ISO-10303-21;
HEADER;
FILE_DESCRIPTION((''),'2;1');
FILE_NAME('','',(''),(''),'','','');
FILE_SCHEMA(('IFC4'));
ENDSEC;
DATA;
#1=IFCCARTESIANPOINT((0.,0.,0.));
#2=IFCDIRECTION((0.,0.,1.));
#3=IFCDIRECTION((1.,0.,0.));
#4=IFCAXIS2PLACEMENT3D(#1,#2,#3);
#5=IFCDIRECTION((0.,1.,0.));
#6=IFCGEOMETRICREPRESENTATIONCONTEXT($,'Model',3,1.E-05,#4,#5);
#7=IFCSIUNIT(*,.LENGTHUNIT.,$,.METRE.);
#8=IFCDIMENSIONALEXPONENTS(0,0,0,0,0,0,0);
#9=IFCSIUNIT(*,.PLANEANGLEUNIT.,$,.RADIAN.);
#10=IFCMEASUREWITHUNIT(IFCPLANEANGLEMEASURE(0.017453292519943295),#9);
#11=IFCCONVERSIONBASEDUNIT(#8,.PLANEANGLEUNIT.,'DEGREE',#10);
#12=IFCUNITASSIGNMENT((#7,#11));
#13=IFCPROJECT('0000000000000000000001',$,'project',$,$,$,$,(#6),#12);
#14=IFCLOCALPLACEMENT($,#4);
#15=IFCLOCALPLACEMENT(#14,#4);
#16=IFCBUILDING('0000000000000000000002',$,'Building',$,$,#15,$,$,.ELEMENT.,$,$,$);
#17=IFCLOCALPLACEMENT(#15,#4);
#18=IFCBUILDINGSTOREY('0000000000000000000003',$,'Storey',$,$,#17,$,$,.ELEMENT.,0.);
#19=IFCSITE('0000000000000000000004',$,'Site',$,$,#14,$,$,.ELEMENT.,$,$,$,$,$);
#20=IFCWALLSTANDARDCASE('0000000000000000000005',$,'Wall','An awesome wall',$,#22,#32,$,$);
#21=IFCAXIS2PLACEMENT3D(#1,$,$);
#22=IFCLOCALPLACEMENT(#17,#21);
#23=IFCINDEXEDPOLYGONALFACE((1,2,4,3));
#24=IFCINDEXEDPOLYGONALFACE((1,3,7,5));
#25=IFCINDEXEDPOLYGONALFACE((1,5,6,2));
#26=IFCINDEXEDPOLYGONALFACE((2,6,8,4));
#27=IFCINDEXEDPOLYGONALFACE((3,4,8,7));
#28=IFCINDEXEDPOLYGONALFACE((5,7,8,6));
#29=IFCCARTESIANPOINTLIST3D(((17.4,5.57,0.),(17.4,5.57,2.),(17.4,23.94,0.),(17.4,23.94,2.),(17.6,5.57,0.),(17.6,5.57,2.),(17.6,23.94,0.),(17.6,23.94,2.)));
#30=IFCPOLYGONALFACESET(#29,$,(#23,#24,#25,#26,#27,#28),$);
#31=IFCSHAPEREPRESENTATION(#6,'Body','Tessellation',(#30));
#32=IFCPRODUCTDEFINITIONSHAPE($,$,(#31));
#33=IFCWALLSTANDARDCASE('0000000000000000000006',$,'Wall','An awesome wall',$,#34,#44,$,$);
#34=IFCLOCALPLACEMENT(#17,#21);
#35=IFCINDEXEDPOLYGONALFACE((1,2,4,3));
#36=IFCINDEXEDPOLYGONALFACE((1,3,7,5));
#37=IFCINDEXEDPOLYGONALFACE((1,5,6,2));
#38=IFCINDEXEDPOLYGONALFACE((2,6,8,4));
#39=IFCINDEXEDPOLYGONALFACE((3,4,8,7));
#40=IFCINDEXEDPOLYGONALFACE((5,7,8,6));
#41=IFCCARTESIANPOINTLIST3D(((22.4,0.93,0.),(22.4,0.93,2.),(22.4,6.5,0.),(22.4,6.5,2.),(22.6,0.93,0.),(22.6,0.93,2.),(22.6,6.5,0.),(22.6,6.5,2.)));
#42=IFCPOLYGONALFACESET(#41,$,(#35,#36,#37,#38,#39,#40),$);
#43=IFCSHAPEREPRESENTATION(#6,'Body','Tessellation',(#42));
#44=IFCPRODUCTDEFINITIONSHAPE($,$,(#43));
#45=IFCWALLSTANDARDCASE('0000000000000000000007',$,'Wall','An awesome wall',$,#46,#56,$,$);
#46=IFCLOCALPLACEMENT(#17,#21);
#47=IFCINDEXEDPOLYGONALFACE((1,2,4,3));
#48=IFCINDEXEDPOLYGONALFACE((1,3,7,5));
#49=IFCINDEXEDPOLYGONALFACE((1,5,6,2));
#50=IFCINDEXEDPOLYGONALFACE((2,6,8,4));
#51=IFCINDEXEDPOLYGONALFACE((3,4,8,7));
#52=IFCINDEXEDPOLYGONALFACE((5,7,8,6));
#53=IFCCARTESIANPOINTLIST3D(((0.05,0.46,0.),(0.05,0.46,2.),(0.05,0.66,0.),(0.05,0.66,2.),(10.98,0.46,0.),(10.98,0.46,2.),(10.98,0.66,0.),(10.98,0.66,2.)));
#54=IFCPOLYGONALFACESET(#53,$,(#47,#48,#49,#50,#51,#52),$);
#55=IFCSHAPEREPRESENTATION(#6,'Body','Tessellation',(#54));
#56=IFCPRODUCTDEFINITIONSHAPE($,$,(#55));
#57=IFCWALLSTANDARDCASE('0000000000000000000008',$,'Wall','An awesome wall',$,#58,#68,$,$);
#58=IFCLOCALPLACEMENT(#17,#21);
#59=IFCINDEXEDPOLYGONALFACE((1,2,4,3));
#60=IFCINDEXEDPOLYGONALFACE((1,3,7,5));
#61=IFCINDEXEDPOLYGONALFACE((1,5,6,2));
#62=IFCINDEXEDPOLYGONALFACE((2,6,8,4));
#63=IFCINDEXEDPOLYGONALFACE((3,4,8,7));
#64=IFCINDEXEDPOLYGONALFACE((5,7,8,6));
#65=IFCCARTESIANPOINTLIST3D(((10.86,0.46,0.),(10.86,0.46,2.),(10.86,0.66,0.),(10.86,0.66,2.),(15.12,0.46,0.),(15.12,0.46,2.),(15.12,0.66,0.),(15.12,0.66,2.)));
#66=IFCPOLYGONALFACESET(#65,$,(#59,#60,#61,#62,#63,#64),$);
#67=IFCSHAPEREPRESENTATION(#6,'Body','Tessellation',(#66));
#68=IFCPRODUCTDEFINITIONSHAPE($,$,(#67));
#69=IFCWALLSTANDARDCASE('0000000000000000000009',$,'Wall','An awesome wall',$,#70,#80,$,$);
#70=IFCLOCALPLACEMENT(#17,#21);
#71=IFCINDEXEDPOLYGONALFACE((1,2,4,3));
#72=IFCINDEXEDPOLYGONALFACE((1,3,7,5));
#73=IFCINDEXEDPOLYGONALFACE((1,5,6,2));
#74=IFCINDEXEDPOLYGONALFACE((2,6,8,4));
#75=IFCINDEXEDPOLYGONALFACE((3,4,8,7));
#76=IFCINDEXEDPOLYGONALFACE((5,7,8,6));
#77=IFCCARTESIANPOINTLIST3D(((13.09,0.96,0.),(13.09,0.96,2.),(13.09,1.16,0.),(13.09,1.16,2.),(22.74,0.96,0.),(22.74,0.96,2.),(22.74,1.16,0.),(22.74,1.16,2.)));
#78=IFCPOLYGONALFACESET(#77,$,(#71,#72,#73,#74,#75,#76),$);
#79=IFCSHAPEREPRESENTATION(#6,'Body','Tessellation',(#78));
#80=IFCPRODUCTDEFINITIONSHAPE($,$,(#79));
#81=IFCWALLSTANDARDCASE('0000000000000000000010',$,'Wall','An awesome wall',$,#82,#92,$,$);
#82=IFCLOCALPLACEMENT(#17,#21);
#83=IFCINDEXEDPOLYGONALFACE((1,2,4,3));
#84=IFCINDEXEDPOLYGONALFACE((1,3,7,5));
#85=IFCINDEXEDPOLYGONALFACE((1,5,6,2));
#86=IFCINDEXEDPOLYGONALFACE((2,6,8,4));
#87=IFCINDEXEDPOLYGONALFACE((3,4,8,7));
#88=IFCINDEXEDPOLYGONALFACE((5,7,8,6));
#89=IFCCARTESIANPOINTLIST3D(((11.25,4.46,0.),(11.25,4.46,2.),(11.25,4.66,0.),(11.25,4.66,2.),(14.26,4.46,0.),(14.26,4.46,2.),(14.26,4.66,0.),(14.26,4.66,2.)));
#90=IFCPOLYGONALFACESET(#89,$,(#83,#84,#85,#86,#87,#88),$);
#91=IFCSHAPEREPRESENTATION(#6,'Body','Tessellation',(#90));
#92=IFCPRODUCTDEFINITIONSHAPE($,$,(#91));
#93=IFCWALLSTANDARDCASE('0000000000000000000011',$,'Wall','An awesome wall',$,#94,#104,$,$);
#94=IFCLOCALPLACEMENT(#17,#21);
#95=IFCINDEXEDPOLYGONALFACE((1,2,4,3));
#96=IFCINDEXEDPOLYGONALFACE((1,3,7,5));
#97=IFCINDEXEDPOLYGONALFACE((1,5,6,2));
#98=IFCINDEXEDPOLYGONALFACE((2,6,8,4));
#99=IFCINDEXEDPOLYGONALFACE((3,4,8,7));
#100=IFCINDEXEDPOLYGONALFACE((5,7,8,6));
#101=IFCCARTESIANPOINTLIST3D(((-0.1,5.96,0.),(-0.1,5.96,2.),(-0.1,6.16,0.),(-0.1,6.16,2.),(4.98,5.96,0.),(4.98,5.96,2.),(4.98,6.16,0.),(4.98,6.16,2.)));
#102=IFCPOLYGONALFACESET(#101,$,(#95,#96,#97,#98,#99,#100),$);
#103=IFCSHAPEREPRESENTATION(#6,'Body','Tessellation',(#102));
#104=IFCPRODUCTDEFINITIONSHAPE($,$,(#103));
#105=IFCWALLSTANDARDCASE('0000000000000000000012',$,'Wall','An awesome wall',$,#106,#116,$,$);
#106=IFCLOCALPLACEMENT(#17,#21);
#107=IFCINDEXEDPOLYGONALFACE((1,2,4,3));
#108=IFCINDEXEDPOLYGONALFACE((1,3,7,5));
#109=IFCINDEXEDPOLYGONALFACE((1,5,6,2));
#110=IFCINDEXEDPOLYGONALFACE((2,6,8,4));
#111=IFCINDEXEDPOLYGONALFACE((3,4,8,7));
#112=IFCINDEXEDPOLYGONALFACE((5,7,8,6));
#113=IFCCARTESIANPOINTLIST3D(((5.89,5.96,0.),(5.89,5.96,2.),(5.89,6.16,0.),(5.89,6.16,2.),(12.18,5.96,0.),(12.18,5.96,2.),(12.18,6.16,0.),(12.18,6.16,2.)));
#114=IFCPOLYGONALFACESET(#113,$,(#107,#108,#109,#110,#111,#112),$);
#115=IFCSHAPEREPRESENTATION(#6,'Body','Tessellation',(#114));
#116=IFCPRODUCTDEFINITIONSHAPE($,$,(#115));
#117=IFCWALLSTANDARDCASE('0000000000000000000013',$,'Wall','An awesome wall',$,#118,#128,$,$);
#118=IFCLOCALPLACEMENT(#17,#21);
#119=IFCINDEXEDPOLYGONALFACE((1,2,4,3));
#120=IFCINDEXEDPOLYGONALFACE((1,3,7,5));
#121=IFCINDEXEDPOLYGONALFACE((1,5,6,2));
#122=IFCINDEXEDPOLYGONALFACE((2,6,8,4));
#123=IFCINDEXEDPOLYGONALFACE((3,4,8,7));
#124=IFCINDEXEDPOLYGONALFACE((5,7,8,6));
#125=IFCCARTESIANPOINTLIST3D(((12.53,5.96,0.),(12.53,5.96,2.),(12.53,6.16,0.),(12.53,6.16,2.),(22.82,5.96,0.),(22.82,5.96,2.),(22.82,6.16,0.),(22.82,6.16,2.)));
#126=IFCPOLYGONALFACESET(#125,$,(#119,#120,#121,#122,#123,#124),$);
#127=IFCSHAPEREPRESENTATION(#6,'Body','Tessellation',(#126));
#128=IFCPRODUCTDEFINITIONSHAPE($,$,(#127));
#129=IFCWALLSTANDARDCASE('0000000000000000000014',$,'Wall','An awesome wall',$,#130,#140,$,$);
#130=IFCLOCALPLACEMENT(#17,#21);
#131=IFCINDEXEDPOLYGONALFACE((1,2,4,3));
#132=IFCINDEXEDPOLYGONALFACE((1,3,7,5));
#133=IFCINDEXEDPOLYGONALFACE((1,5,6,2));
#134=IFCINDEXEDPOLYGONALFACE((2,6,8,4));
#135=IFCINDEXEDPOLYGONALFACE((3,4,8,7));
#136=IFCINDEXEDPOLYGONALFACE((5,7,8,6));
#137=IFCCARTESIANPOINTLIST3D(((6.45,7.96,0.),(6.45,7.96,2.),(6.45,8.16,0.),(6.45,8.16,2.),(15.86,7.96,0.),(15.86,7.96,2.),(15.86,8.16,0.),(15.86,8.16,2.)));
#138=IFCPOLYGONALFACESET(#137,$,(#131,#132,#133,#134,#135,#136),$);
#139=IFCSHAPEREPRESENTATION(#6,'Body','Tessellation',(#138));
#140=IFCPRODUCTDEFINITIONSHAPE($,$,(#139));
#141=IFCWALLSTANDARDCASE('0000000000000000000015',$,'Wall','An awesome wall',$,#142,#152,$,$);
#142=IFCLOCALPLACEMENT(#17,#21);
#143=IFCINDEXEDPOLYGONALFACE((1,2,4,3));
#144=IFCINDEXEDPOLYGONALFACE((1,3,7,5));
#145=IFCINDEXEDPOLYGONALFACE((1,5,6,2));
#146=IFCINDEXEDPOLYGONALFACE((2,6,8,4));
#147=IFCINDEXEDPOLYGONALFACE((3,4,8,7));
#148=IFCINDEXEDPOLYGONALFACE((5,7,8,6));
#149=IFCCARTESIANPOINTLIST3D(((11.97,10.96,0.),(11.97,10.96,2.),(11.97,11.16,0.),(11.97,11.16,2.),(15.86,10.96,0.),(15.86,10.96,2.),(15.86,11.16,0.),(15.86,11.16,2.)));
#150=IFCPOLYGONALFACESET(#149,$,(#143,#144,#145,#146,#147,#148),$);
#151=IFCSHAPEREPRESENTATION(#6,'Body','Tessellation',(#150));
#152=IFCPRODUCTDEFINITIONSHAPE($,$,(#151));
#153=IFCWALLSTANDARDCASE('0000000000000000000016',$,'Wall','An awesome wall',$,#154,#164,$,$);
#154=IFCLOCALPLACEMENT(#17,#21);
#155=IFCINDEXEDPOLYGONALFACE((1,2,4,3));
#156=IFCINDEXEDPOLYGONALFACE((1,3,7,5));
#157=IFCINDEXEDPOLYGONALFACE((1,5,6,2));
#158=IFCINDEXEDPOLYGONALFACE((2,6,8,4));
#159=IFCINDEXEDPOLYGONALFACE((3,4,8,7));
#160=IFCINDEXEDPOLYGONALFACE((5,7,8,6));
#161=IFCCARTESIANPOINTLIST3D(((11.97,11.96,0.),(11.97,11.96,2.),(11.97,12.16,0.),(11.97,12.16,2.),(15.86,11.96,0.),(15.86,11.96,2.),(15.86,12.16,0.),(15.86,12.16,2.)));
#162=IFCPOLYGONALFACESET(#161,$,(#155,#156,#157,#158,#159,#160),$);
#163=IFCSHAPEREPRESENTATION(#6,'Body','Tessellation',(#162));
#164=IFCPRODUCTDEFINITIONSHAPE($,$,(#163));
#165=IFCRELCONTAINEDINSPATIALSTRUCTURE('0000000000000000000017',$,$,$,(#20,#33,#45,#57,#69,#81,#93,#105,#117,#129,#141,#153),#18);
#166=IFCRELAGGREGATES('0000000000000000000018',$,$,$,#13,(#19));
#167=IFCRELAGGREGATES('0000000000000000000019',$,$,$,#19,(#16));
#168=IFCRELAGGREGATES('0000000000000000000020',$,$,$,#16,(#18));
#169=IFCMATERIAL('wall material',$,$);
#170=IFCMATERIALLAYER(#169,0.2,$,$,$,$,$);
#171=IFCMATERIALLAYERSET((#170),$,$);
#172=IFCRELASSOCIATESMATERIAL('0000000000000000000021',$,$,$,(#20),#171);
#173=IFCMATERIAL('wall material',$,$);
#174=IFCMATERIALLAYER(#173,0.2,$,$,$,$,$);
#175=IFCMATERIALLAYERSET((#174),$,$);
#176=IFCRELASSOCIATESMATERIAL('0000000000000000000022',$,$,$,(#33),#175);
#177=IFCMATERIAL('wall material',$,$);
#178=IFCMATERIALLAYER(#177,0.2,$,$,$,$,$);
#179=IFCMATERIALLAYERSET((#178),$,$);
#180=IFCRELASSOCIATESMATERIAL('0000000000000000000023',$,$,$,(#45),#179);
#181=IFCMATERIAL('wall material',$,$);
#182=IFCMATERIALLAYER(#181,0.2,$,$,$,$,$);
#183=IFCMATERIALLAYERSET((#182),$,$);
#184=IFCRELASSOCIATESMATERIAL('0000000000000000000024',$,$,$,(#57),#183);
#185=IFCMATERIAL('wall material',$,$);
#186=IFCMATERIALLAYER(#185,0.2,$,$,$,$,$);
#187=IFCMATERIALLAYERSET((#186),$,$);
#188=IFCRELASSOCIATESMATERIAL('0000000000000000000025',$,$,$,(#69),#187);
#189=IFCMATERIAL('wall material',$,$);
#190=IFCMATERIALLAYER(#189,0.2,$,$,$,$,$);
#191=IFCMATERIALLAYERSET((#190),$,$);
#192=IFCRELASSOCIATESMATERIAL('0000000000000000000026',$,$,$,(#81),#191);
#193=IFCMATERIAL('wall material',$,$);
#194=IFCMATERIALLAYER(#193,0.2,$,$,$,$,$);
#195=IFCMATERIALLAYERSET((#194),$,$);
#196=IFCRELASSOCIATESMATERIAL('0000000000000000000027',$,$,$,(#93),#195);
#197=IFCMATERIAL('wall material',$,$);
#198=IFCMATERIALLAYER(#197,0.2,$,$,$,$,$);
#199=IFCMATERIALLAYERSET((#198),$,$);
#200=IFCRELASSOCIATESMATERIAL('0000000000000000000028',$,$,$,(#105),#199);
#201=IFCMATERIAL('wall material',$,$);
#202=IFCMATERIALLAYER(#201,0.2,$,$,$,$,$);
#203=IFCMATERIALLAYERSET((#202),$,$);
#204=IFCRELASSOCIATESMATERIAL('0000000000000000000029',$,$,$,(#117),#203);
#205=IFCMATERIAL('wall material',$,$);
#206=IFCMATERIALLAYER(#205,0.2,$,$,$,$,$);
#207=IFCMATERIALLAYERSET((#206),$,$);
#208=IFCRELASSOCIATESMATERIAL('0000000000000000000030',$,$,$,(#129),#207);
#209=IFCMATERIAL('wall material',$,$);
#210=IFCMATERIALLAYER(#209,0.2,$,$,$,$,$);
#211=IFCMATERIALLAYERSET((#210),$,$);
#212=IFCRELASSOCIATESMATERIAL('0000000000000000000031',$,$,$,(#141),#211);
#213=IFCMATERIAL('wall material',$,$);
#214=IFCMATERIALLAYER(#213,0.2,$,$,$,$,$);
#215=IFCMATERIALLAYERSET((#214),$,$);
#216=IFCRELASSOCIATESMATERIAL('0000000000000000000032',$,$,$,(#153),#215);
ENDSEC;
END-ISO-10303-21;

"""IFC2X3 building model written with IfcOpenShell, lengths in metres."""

from ifc_helpers import new_model, entity, si_unit, converted_unit, direction, frame, origin_with_axes, place, context, project, spatial, polyline, outline, extrude, material, layer, layer_set, layer_usage, element, save


model = new_model("IFC2X3")

# Units and contexts
model_context = context("Model", 3, precision=1e-05, world=origin_with_axes(), true_north=direction((0.0, 1.0, 0.0)))
ifc_project = project(units=[si_unit("LENGTHUNIT", "METRE"), converted_unit("PLANEANGLEUNIT", "DEGREE", entity("IfcPlaneAngleMeasure", 0.017453292519943295), si_unit("PLANEANGLEUNIT", "RADIAN"), dimensions=[0, 0, 0, 0, 0, 0, 0])], contexts=[model_context])

# Site, building, storey
site_placement = place(None, origin_with_axes())
site = spatial("IfcSite", under=ifc_project, at=site_placement, Name="Site", CompositionType="ELEMENT")
building_placement = place(site_placement, origin_with_axes())
building = spatial("IfcBuilding", under=site, at=building_placement, Name="Building", CompositionType="ELEMENT")
storey_placement = place(building_placement, origin_with_axes())
storey = spatial("IfcBuildingStorey", under=building, at=storey_placement, Name="Storey", CompositionType="ELEMENT", Elevation=0.0)

# Walls
ifc_material_1 = material(Name="wall material")
ifc_layer_1 = layer(ifc_material_1, 0.2)
ifc_layer_set_1 = layer_set([ifc_layer_1])
ifc_layer_usage_1 = layer_usage(ifc_layer_set_1, "AXIS2", "POSITIVE", -0.1)
wall_1_placement = place(storey_placement, origin_with_axes())
element("IfcWallStandardCase", 1, at=wall_1_placement, inside=storey, material=ifc_layer_usage_1, Name="Wall", Description="An awesome wall", context=model_context, shape_type="SweptSolid", body=[
    extrude(outline(polyline([(0.0, -0.1, 0.0), (18.37, -0.1, 0.0), (18.37, 0.1, 0.0), (0.0, 0.1, 0.0), (0.0, -0.1, 0.0)])), frame((17.5, 5.57, 0.0), z_axis=(0.0, 0.0, 1.0), x_axis=(0.0, 1.0, 0.0)), (0.0, 0.0, 1.0), 2.0),
])
ifc_material_2 = material(Name="wall material")
ifc_layer_2 = layer(ifc_material_2, 0.2)
ifc_layer_set_2 = layer_set([ifc_layer_2])
ifc_layer_usage_2 = layer_usage(ifc_layer_set_2, "AXIS2", "POSITIVE", -0.1)
wall_2_placement = place(storey_placement, origin_with_axes())
element("IfcWallStandardCase", 2, at=wall_2_placement, inside=storey, material=ifc_layer_usage_2, Name="Wall", Description="An awesome wall", context=model_context, shape_type="SweptSolid", body=[
    extrude(outline(polyline([(0.0, -0.1, 0.0), (5.57, -0.1, 0.0), (5.57, 0.1, 0.0), (0.0, 0.1, 0.0), (0.0, -0.1, 0.0)])), frame((22.5, 0.93, 0.0), z_axis=(0.0, 0.0, 1.0), x_axis=(0.0, 1.0, 0.0)), (0.0, 0.0, 1.0), 2.0),
])
ifc_material_3 = material(Name="wall material")
ifc_layer_3 = layer(ifc_material_3, 0.2)
ifc_layer_set_3 = layer_set([ifc_layer_3])
ifc_layer_usage_3 = layer_usage(ifc_layer_set_3, "AXIS2", "POSITIVE", -0.1)
wall_3_placement = place(storey_placement, origin_with_axes())
element("IfcWallStandardCase", 3, at=wall_3_placement, inside=storey, material=ifc_layer_usage_3, Name="Wall", Description="An awesome wall", context=model_context, shape_type="SweptSolid", body=[
    extrude(outline(polyline([(0.0, -0.1, 0.0), (10.93, -0.1, 0.0), (10.93, 0.1, 0.0), (0.0, 0.1, 0.0), (0.0, -0.1, 0.0)])), frame((0.05, 0.56, 0.0), z_axis=(0.0, 0.0, 1.0), x_axis=(1.0, 0.0, 0.0)), (0.0, 0.0, 1.0), 2.0),
])
ifc_material_4 = material(Name="wall material")
ifc_layer_4 = layer(ifc_material_4, 0.2)
ifc_layer_set_4 = layer_set([ifc_layer_4])
ifc_layer_usage_4 = layer_usage(ifc_layer_set_4, "AXIS2", "POSITIVE", -0.1)
wall_4_placement = place(storey_placement, origin_with_axes())
element("IfcWallStandardCase", 4, at=wall_4_placement, inside=storey, material=ifc_layer_usage_4, Name="Wall", Description="An awesome wall", context=model_context, shape_type="SweptSolid", body=[
    extrude(outline(polyline([(0.0, -0.1, 0.0), (4.26, -0.1, 0.0), (4.26, 0.1, 0.0), (0.0, 0.1, 0.0), (0.0, -0.1, 0.0)])), frame((10.86, 0.56, 0.0), z_axis=(0.0, 0.0, 1.0), x_axis=(1.0, 0.0, 0.0)), (0.0, 0.0, 1.0), 2.0),
])
ifc_material_5 = material(Name="wall material")
ifc_layer_5 = layer(ifc_material_5, 0.2)
ifc_layer_set_5 = layer_set([ifc_layer_5])
ifc_layer_usage_5 = layer_usage(ifc_layer_set_5, "AXIS2", "POSITIVE", -0.1)
wall_5_placement = place(storey_placement, origin_with_axes())
element("IfcWallStandardCase", 5, at=wall_5_placement, inside=storey, material=ifc_layer_usage_5, Name="Wall", Description="An awesome wall", context=model_context, shape_type="SweptSolid", body=[
    extrude(outline(polyline([(0.0, -0.1, 0.0), (9.65, -0.1, 0.0), (9.65, 0.1, 0.0), (0.0, 0.1, 0.0), (0.0, -0.1, 0.0)])), frame((13.09, 1.06, 0.0), z_axis=(0.0, 0.0, 1.0), x_axis=(1.0, 0.0, 0.0)), (0.0, 0.0, 1.0), 2.0),
])
ifc_material_6 = material(Name="wall material")
ifc_layer_6 = layer(ifc_material_6, 0.2)
ifc_layer_set_6 = layer_set([ifc_layer_6])
ifc_layer_usage_6 = layer_usage(ifc_layer_set_6, "AXIS2", "POSITIVE", -0.1)
wall_6_placement = place(storey_placement, origin_with_axes())
element("IfcWallStandardCase", 6, at=wall_6_placement, inside=storey, material=ifc_layer_usage_6, Name="Wall", Description="An awesome wall", context=model_context, shape_type="SweptSolid", body=[
    extrude(outline(polyline([(0.0, -0.1, 0.0), (3.01, -0.1, 0.0), (3.01, 0.1, 0.0), (0.0, 0.1, 0.0), (0.0, -0.1, 0.0)])), frame((11.25, 4.56, 0.0), z_axis=(0.0, 0.0, 1.0), x_axis=(1.0, 0.0, 0.0)), (0.0, 0.0, 1.0), 2.0),
])
ifc_material_7 = material(Name="wall material")
ifc_layer_7 = layer(ifc_material_7, 0.2)
ifc_layer_set_7 = layer_set([ifc_layer_7])
ifc_layer_usage_7 = layer_usage(ifc_layer_set_7, "AXIS2", "POSITIVE", -0.1)
wall_7_placement = place(storey_placement, origin_with_axes())
element("IfcWallStandardCase", 7, at=wall_7_placement, inside=storey, material=ifc_layer_usage_7, Name="Wall", Description="An awesome wall", context=model_context, shape_type="SweptSolid", body=[
    extrude(outline(polyline([(0.0, -0.1, 0.0), (5.08, -0.1, 0.0), (5.08, 0.1, 0.0), (0.0, 0.1, 0.0), (0.0, -0.1, 0.0)])), frame((-0.1, 6.06, 0.0), z_axis=(0.0, 0.0, 1.0), x_axis=(1.0, 0.0, 0.0)), (0.0, 0.0, 1.0), 2.0),
])
ifc_material_8 = material(Name="wall material")
ifc_layer_8 = layer(ifc_material_8, 0.2)
ifc_layer_set_8 = layer_set([ifc_layer_8])
ifc_layer_usage_8 = layer_usage(ifc_layer_set_8, "AXIS2", "POSITIVE", -0.1)
wall_8_placement = place(storey_placement, origin_with_axes())
element("IfcWallStandardCase", 8, at=wall_8_placement, inside=storey, material=ifc_layer_usage_8, Name="Wall", Description="An awesome wall", context=model_context, shape_type="SweptSolid", body=[
    extrude(outline(polyline([(0.0, -0.1, 0.0), (6.29, -0.1, 0.0), (6.29, 0.1, 0.0), (0.0, 0.1, 0.0), (0.0, -0.1, 0.0)])), frame((5.89, 6.06, 0.0), z_axis=(0.0, 0.0, 1.0), x_axis=(1.0, 0.0, 0.0)), (0.0, 0.0, 1.0), 2.0),
])
ifc_material_9 = material(Name="wall material")
ifc_layer_9 = layer(ifc_material_9, 0.2)
ifc_layer_set_9 = layer_set([ifc_layer_9])
ifc_layer_usage_9 = layer_usage(ifc_layer_set_9, "AXIS2", "POSITIVE", -0.1)
wall_9_placement = place(storey_placement, origin_with_axes())
element("IfcWallStandardCase", 9, at=wall_9_placement, inside=storey, material=ifc_layer_usage_9, Name="Wall", Description="An awesome wall", context=model_context, shape_type="SweptSolid", body=[
    extrude(outline(polyline([(0.0, -0.1, 0.0), (10.29, -0.1, 0.0), (10.29, 0.1, 0.0), (0.0, 0.1, 0.0), (0.0, -0.1, 0.0)])), frame((12.53, 6.06, 0.0), z_axis=(0.0, 0.0, 1.0), x_axis=(1.0, 0.0, 0.0)), (0.0, 0.0, 1.0), 2.0),
])
ifc_material_10 = material(Name="wall material")
ifc_layer_10 = layer(ifc_material_10, 0.2)
ifc_layer_set_10 = layer_set([ifc_layer_10])
ifc_layer_usage_10 = layer_usage(ifc_layer_set_10, "AXIS2", "POSITIVE", -0.1)
wall_10_placement = place(storey_placement, origin_with_axes())
element("IfcWallStandardCase", 10, at=wall_10_placement, inside=storey, material=ifc_layer_usage_10, Name="Wall", Description="An awesome wall", context=model_context, shape_type="SweptSolid", body=[
    extrude(outline(polyline([(0.0, -0.1, 0.0), (9.41, -0.1, 0.0), (9.41, 0.1, 0.0), (0.0, 0.1, 0.0), (0.0, -0.1, 0.0)])), frame((6.45, 8.06, 0.0), z_axis=(0.0, 0.0, 1.0), x_axis=(1.0, 0.0, 0.0)), (0.0, 0.0, 1.0), 2.0),
])
ifc_material_11 = material(Name="wall material")
ifc_layer_11 = layer(ifc_material_11, 0.2)
ifc_layer_set_11 = layer_set([ifc_layer_11])
ifc_layer_usage_11 = layer_usage(ifc_layer_set_11, "AXIS2", "POSITIVE", -0.1)
wall_11_placement = place(storey_placement, origin_with_axes())
element("IfcWallStandardCase", 11, at=wall_11_placement, inside=storey, material=ifc_layer_usage_11, Name="Wall", Description="An awesome wall", context=model_context, shape_type="SweptSolid", body=[
    extrude(outline(polyline([(0.0, -0.1, 0.0), (3.89, -0.1, 0.0), (3.89, 0.1, 0.0), (0.0, 0.1, 0.0), (0.0, -0.1, 0.0)])), frame((11.97, 11.06, 0.0), z_axis=(0.0, 0.0, 1.0), x_axis=(1.0, 0.0, 0.0)), (0.0, 0.0, 1.0), 2.0),
])
ifc_material_12 = material(Name="wall material")
ifc_layer_12 = layer(ifc_material_12, 0.2)
ifc_layer_set_12 = layer_set([ifc_layer_12])
ifc_layer_usage_12 = layer_usage(ifc_layer_set_12, "AXIS2", "POSITIVE", -0.1)
wall_12_placement = place(storey_placement, origin_with_axes())
element("IfcWallStandardCase", 12, at=wall_12_placement, inside=storey, material=ifc_layer_usage_12, Name="Wall", Description="An awesome wall", context=model_context, shape_type="SweptSolid", body=[
    extrude(outline(polyline([(0.0, -0.1, 0.0), (3.89, -0.1, 0.0), (3.89, 0.1, 0.0), (0.0, 0.1, 0.0), (0.0, -0.1, 0.0)])), frame((11.97, 12.06, 0.0), z_axis=(0.0, 0.0, 1.0), x_axis=(1.0, 0.0, 0.0)), (0.0, 0.0, 1.0), 2.0),
])

save(model, "model.ifc")
